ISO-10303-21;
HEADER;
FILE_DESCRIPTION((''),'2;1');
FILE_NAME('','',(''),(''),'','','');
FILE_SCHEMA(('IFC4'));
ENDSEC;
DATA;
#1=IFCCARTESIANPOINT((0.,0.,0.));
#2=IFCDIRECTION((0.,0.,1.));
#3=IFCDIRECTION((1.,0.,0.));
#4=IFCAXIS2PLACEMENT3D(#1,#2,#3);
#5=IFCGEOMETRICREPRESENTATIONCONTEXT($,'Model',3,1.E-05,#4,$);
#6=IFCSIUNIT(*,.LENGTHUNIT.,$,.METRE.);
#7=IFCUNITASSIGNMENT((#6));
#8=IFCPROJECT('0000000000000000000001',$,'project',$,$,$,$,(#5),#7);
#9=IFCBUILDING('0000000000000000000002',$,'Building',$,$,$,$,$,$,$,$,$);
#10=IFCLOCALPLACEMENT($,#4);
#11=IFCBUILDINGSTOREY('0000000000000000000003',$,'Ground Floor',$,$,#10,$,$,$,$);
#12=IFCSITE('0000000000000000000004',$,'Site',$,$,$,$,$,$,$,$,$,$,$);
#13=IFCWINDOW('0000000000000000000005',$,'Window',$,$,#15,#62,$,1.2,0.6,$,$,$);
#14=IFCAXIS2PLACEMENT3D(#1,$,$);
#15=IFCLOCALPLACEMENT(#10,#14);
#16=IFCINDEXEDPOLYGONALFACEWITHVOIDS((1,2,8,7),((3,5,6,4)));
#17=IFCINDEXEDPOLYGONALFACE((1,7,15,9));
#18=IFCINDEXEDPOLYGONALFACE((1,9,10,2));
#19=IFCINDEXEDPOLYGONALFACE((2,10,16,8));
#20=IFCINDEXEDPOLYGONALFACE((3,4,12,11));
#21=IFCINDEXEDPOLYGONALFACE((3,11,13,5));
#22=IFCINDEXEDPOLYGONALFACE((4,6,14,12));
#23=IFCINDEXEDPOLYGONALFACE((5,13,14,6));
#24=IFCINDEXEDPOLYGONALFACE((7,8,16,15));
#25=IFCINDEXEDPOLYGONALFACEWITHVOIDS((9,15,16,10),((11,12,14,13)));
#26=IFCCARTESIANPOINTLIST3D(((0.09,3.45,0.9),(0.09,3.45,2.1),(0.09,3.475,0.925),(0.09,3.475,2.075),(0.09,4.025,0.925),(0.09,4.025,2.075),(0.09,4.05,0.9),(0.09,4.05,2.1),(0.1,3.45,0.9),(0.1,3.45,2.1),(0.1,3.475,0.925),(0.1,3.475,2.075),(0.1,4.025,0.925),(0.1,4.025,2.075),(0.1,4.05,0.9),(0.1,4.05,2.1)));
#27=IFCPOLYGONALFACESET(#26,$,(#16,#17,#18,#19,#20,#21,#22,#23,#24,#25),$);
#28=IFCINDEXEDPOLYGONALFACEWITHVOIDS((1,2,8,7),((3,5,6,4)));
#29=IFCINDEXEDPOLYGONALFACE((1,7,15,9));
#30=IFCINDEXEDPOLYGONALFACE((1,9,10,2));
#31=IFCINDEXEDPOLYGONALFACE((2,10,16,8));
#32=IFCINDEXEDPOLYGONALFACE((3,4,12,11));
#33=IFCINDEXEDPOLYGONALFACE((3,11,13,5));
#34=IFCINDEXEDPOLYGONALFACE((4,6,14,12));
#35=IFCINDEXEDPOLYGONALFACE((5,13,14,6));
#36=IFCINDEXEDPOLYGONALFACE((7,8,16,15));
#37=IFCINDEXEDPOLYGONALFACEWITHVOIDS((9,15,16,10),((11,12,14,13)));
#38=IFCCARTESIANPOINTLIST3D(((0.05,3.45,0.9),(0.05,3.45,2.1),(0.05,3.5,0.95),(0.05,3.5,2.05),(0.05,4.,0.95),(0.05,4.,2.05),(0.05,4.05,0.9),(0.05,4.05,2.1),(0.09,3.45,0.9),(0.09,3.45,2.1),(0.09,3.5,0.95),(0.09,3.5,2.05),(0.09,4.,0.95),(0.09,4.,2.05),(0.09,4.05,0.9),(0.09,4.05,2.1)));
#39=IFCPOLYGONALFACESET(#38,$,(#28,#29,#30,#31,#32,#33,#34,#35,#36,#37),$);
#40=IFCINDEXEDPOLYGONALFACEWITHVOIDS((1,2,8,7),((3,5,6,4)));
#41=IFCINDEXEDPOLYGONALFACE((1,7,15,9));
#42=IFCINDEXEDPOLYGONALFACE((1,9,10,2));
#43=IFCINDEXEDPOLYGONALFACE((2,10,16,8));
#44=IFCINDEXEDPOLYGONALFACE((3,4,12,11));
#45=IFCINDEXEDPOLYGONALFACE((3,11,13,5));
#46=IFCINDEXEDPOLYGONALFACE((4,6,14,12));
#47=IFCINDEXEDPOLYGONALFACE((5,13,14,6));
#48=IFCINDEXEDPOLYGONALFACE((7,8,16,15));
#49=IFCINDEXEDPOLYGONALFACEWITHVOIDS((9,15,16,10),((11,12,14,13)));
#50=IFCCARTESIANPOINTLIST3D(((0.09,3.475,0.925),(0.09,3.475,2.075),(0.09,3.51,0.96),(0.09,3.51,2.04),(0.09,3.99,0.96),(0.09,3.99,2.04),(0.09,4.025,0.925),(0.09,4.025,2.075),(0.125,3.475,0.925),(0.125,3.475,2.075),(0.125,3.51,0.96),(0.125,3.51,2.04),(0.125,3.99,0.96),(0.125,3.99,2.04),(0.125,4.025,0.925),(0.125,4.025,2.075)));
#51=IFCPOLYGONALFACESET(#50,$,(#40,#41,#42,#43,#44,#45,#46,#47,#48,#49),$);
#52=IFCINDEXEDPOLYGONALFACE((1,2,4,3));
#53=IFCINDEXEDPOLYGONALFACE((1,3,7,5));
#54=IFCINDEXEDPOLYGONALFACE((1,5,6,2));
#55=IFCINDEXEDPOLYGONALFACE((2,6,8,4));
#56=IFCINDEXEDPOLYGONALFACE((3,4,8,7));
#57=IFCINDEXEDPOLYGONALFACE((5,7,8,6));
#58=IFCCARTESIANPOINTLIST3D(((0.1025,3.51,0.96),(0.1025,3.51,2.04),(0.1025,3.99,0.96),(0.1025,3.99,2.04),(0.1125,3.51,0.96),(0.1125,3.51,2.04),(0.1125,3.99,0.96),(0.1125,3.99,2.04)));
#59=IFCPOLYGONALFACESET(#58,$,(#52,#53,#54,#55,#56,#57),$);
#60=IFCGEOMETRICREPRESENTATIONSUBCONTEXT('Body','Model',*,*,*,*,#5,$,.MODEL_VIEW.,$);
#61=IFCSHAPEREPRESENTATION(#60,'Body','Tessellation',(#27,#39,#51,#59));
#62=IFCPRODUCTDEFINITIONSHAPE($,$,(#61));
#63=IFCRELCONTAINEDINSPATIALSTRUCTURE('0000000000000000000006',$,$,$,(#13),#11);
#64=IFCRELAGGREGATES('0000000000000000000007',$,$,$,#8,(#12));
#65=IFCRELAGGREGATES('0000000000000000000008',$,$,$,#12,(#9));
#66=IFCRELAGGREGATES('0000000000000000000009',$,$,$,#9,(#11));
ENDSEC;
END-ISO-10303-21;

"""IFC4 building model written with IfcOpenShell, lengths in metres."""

from ifc_helpers import new_model, si_unit, frame, origin_with_axes, place, context, subcontext, project, spatial, line, indexed_curve, outline, extrude, element, save


model = new_model("IFC4")

# Units and contexts
model_context = context("Model", 3, precision=1e-05, world=origin_with_axes())
body_context = subcontext(model_context, "Body", "Model", "MODEL_VIEW")
ifc_project = project(units=[si_unit("LENGTHUNIT", "METRE")], contexts=[model_context])

# Site, building, storey
site = spatial("IfcSite", under=ifc_project, Name="Site")
building = spatial("IfcBuilding", under=site, Name="Building")
storey_placement = place(None, origin_with_axes())
storey = spatial("IfcBuildingStorey", under=building, at=storey_placement, Name="Ground Floor")

# Window
window_1_placement = place(storey_placement, frame((0.0, 4.05, 0.9), z_axis=(0.0, 0.0, 1.0), x_axis=(0.0, -1.0, 0.0)))
element("IfcWindow", 1, at=window_1_placement, inside=storey, Name="Window", OverallHeight=1.2, OverallWidth=0.6, context=body_context, shape_type="SweptSolid", body=[
    extrude(outline(indexed_curve([(0.0, 0.0), (0.6, 0.0), (0.6, 1.2), (0.0, 1.2)], segments=[line(1, 2, 3, 4, 1)]), holes=[indexed_curve([(0.025, 0.025), (0.575, 0.025), (0.575, 1.175), (0.025, 1.175)], segments=[line(1, 2, 3, 4, 1)])]), frame((0.0, 0.09, 0.0), z_axis=(0.0, -1.0, 0.0), x_axis=(1.0, 0.0, 0.0)), (0.0, 0.0, -1.0), 0.01),
    extrude(outline(indexed_curve([(0.0, 0.0), (0.6, 0.0), (0.6, 1.2), (0.0, 1.2)], segments=[line(1, 2, 3, 4, 1)]), holes=[indexed_curve([(0.05, 0.05), (0.55, 0.05), (0.55, 1.15), (0.05, 1.15)], segments=[line(1, 2, 3, 4, 1)])]), frame((0.0, 0.05, 0.0), z_axis=(0.0, -1.0, 0.0), x_axis=(1.0, 0.0, 0.0)), (0.0, 0.0, -1.0), 0.04),
    extrude(outline(indexed_curve([(0.0, 0.0), (0.55, 0.0), (0.55, 1.15), (0.0, 1.15)], segments=[line(1, 2, 3, 4, 1)]), holes=[indexed_curve([(0.035, 0.035), (0.515, 0.035), (0.515, 1.115), (0.035, 1.115)], segments=[line(1, 2, 3, 4, 1)])]), frame((0.025, 0.09, 0.025), z_axis=(0.0, -1.0, 0.0), x_axis=(1.0, 0.0, 0.0)), (0.0, 0.0, -1.0), 0.035),
    extrude(outline(indexed_curve([(0.035, 0.035), (0.515, 0.035), (0.515, 1.115), (0.035, 1.115)], segments=[line(1, 2, 3, 4, 1)])), frame((0.025, 0.1025, 0.025), z_axis=(0.0, -1.0, 0.0), x_axis=(1.0, 0.0, 0.0)), (0.0, 0.0, -1.0), 0.01),
])

save(model, "model.ifc")
